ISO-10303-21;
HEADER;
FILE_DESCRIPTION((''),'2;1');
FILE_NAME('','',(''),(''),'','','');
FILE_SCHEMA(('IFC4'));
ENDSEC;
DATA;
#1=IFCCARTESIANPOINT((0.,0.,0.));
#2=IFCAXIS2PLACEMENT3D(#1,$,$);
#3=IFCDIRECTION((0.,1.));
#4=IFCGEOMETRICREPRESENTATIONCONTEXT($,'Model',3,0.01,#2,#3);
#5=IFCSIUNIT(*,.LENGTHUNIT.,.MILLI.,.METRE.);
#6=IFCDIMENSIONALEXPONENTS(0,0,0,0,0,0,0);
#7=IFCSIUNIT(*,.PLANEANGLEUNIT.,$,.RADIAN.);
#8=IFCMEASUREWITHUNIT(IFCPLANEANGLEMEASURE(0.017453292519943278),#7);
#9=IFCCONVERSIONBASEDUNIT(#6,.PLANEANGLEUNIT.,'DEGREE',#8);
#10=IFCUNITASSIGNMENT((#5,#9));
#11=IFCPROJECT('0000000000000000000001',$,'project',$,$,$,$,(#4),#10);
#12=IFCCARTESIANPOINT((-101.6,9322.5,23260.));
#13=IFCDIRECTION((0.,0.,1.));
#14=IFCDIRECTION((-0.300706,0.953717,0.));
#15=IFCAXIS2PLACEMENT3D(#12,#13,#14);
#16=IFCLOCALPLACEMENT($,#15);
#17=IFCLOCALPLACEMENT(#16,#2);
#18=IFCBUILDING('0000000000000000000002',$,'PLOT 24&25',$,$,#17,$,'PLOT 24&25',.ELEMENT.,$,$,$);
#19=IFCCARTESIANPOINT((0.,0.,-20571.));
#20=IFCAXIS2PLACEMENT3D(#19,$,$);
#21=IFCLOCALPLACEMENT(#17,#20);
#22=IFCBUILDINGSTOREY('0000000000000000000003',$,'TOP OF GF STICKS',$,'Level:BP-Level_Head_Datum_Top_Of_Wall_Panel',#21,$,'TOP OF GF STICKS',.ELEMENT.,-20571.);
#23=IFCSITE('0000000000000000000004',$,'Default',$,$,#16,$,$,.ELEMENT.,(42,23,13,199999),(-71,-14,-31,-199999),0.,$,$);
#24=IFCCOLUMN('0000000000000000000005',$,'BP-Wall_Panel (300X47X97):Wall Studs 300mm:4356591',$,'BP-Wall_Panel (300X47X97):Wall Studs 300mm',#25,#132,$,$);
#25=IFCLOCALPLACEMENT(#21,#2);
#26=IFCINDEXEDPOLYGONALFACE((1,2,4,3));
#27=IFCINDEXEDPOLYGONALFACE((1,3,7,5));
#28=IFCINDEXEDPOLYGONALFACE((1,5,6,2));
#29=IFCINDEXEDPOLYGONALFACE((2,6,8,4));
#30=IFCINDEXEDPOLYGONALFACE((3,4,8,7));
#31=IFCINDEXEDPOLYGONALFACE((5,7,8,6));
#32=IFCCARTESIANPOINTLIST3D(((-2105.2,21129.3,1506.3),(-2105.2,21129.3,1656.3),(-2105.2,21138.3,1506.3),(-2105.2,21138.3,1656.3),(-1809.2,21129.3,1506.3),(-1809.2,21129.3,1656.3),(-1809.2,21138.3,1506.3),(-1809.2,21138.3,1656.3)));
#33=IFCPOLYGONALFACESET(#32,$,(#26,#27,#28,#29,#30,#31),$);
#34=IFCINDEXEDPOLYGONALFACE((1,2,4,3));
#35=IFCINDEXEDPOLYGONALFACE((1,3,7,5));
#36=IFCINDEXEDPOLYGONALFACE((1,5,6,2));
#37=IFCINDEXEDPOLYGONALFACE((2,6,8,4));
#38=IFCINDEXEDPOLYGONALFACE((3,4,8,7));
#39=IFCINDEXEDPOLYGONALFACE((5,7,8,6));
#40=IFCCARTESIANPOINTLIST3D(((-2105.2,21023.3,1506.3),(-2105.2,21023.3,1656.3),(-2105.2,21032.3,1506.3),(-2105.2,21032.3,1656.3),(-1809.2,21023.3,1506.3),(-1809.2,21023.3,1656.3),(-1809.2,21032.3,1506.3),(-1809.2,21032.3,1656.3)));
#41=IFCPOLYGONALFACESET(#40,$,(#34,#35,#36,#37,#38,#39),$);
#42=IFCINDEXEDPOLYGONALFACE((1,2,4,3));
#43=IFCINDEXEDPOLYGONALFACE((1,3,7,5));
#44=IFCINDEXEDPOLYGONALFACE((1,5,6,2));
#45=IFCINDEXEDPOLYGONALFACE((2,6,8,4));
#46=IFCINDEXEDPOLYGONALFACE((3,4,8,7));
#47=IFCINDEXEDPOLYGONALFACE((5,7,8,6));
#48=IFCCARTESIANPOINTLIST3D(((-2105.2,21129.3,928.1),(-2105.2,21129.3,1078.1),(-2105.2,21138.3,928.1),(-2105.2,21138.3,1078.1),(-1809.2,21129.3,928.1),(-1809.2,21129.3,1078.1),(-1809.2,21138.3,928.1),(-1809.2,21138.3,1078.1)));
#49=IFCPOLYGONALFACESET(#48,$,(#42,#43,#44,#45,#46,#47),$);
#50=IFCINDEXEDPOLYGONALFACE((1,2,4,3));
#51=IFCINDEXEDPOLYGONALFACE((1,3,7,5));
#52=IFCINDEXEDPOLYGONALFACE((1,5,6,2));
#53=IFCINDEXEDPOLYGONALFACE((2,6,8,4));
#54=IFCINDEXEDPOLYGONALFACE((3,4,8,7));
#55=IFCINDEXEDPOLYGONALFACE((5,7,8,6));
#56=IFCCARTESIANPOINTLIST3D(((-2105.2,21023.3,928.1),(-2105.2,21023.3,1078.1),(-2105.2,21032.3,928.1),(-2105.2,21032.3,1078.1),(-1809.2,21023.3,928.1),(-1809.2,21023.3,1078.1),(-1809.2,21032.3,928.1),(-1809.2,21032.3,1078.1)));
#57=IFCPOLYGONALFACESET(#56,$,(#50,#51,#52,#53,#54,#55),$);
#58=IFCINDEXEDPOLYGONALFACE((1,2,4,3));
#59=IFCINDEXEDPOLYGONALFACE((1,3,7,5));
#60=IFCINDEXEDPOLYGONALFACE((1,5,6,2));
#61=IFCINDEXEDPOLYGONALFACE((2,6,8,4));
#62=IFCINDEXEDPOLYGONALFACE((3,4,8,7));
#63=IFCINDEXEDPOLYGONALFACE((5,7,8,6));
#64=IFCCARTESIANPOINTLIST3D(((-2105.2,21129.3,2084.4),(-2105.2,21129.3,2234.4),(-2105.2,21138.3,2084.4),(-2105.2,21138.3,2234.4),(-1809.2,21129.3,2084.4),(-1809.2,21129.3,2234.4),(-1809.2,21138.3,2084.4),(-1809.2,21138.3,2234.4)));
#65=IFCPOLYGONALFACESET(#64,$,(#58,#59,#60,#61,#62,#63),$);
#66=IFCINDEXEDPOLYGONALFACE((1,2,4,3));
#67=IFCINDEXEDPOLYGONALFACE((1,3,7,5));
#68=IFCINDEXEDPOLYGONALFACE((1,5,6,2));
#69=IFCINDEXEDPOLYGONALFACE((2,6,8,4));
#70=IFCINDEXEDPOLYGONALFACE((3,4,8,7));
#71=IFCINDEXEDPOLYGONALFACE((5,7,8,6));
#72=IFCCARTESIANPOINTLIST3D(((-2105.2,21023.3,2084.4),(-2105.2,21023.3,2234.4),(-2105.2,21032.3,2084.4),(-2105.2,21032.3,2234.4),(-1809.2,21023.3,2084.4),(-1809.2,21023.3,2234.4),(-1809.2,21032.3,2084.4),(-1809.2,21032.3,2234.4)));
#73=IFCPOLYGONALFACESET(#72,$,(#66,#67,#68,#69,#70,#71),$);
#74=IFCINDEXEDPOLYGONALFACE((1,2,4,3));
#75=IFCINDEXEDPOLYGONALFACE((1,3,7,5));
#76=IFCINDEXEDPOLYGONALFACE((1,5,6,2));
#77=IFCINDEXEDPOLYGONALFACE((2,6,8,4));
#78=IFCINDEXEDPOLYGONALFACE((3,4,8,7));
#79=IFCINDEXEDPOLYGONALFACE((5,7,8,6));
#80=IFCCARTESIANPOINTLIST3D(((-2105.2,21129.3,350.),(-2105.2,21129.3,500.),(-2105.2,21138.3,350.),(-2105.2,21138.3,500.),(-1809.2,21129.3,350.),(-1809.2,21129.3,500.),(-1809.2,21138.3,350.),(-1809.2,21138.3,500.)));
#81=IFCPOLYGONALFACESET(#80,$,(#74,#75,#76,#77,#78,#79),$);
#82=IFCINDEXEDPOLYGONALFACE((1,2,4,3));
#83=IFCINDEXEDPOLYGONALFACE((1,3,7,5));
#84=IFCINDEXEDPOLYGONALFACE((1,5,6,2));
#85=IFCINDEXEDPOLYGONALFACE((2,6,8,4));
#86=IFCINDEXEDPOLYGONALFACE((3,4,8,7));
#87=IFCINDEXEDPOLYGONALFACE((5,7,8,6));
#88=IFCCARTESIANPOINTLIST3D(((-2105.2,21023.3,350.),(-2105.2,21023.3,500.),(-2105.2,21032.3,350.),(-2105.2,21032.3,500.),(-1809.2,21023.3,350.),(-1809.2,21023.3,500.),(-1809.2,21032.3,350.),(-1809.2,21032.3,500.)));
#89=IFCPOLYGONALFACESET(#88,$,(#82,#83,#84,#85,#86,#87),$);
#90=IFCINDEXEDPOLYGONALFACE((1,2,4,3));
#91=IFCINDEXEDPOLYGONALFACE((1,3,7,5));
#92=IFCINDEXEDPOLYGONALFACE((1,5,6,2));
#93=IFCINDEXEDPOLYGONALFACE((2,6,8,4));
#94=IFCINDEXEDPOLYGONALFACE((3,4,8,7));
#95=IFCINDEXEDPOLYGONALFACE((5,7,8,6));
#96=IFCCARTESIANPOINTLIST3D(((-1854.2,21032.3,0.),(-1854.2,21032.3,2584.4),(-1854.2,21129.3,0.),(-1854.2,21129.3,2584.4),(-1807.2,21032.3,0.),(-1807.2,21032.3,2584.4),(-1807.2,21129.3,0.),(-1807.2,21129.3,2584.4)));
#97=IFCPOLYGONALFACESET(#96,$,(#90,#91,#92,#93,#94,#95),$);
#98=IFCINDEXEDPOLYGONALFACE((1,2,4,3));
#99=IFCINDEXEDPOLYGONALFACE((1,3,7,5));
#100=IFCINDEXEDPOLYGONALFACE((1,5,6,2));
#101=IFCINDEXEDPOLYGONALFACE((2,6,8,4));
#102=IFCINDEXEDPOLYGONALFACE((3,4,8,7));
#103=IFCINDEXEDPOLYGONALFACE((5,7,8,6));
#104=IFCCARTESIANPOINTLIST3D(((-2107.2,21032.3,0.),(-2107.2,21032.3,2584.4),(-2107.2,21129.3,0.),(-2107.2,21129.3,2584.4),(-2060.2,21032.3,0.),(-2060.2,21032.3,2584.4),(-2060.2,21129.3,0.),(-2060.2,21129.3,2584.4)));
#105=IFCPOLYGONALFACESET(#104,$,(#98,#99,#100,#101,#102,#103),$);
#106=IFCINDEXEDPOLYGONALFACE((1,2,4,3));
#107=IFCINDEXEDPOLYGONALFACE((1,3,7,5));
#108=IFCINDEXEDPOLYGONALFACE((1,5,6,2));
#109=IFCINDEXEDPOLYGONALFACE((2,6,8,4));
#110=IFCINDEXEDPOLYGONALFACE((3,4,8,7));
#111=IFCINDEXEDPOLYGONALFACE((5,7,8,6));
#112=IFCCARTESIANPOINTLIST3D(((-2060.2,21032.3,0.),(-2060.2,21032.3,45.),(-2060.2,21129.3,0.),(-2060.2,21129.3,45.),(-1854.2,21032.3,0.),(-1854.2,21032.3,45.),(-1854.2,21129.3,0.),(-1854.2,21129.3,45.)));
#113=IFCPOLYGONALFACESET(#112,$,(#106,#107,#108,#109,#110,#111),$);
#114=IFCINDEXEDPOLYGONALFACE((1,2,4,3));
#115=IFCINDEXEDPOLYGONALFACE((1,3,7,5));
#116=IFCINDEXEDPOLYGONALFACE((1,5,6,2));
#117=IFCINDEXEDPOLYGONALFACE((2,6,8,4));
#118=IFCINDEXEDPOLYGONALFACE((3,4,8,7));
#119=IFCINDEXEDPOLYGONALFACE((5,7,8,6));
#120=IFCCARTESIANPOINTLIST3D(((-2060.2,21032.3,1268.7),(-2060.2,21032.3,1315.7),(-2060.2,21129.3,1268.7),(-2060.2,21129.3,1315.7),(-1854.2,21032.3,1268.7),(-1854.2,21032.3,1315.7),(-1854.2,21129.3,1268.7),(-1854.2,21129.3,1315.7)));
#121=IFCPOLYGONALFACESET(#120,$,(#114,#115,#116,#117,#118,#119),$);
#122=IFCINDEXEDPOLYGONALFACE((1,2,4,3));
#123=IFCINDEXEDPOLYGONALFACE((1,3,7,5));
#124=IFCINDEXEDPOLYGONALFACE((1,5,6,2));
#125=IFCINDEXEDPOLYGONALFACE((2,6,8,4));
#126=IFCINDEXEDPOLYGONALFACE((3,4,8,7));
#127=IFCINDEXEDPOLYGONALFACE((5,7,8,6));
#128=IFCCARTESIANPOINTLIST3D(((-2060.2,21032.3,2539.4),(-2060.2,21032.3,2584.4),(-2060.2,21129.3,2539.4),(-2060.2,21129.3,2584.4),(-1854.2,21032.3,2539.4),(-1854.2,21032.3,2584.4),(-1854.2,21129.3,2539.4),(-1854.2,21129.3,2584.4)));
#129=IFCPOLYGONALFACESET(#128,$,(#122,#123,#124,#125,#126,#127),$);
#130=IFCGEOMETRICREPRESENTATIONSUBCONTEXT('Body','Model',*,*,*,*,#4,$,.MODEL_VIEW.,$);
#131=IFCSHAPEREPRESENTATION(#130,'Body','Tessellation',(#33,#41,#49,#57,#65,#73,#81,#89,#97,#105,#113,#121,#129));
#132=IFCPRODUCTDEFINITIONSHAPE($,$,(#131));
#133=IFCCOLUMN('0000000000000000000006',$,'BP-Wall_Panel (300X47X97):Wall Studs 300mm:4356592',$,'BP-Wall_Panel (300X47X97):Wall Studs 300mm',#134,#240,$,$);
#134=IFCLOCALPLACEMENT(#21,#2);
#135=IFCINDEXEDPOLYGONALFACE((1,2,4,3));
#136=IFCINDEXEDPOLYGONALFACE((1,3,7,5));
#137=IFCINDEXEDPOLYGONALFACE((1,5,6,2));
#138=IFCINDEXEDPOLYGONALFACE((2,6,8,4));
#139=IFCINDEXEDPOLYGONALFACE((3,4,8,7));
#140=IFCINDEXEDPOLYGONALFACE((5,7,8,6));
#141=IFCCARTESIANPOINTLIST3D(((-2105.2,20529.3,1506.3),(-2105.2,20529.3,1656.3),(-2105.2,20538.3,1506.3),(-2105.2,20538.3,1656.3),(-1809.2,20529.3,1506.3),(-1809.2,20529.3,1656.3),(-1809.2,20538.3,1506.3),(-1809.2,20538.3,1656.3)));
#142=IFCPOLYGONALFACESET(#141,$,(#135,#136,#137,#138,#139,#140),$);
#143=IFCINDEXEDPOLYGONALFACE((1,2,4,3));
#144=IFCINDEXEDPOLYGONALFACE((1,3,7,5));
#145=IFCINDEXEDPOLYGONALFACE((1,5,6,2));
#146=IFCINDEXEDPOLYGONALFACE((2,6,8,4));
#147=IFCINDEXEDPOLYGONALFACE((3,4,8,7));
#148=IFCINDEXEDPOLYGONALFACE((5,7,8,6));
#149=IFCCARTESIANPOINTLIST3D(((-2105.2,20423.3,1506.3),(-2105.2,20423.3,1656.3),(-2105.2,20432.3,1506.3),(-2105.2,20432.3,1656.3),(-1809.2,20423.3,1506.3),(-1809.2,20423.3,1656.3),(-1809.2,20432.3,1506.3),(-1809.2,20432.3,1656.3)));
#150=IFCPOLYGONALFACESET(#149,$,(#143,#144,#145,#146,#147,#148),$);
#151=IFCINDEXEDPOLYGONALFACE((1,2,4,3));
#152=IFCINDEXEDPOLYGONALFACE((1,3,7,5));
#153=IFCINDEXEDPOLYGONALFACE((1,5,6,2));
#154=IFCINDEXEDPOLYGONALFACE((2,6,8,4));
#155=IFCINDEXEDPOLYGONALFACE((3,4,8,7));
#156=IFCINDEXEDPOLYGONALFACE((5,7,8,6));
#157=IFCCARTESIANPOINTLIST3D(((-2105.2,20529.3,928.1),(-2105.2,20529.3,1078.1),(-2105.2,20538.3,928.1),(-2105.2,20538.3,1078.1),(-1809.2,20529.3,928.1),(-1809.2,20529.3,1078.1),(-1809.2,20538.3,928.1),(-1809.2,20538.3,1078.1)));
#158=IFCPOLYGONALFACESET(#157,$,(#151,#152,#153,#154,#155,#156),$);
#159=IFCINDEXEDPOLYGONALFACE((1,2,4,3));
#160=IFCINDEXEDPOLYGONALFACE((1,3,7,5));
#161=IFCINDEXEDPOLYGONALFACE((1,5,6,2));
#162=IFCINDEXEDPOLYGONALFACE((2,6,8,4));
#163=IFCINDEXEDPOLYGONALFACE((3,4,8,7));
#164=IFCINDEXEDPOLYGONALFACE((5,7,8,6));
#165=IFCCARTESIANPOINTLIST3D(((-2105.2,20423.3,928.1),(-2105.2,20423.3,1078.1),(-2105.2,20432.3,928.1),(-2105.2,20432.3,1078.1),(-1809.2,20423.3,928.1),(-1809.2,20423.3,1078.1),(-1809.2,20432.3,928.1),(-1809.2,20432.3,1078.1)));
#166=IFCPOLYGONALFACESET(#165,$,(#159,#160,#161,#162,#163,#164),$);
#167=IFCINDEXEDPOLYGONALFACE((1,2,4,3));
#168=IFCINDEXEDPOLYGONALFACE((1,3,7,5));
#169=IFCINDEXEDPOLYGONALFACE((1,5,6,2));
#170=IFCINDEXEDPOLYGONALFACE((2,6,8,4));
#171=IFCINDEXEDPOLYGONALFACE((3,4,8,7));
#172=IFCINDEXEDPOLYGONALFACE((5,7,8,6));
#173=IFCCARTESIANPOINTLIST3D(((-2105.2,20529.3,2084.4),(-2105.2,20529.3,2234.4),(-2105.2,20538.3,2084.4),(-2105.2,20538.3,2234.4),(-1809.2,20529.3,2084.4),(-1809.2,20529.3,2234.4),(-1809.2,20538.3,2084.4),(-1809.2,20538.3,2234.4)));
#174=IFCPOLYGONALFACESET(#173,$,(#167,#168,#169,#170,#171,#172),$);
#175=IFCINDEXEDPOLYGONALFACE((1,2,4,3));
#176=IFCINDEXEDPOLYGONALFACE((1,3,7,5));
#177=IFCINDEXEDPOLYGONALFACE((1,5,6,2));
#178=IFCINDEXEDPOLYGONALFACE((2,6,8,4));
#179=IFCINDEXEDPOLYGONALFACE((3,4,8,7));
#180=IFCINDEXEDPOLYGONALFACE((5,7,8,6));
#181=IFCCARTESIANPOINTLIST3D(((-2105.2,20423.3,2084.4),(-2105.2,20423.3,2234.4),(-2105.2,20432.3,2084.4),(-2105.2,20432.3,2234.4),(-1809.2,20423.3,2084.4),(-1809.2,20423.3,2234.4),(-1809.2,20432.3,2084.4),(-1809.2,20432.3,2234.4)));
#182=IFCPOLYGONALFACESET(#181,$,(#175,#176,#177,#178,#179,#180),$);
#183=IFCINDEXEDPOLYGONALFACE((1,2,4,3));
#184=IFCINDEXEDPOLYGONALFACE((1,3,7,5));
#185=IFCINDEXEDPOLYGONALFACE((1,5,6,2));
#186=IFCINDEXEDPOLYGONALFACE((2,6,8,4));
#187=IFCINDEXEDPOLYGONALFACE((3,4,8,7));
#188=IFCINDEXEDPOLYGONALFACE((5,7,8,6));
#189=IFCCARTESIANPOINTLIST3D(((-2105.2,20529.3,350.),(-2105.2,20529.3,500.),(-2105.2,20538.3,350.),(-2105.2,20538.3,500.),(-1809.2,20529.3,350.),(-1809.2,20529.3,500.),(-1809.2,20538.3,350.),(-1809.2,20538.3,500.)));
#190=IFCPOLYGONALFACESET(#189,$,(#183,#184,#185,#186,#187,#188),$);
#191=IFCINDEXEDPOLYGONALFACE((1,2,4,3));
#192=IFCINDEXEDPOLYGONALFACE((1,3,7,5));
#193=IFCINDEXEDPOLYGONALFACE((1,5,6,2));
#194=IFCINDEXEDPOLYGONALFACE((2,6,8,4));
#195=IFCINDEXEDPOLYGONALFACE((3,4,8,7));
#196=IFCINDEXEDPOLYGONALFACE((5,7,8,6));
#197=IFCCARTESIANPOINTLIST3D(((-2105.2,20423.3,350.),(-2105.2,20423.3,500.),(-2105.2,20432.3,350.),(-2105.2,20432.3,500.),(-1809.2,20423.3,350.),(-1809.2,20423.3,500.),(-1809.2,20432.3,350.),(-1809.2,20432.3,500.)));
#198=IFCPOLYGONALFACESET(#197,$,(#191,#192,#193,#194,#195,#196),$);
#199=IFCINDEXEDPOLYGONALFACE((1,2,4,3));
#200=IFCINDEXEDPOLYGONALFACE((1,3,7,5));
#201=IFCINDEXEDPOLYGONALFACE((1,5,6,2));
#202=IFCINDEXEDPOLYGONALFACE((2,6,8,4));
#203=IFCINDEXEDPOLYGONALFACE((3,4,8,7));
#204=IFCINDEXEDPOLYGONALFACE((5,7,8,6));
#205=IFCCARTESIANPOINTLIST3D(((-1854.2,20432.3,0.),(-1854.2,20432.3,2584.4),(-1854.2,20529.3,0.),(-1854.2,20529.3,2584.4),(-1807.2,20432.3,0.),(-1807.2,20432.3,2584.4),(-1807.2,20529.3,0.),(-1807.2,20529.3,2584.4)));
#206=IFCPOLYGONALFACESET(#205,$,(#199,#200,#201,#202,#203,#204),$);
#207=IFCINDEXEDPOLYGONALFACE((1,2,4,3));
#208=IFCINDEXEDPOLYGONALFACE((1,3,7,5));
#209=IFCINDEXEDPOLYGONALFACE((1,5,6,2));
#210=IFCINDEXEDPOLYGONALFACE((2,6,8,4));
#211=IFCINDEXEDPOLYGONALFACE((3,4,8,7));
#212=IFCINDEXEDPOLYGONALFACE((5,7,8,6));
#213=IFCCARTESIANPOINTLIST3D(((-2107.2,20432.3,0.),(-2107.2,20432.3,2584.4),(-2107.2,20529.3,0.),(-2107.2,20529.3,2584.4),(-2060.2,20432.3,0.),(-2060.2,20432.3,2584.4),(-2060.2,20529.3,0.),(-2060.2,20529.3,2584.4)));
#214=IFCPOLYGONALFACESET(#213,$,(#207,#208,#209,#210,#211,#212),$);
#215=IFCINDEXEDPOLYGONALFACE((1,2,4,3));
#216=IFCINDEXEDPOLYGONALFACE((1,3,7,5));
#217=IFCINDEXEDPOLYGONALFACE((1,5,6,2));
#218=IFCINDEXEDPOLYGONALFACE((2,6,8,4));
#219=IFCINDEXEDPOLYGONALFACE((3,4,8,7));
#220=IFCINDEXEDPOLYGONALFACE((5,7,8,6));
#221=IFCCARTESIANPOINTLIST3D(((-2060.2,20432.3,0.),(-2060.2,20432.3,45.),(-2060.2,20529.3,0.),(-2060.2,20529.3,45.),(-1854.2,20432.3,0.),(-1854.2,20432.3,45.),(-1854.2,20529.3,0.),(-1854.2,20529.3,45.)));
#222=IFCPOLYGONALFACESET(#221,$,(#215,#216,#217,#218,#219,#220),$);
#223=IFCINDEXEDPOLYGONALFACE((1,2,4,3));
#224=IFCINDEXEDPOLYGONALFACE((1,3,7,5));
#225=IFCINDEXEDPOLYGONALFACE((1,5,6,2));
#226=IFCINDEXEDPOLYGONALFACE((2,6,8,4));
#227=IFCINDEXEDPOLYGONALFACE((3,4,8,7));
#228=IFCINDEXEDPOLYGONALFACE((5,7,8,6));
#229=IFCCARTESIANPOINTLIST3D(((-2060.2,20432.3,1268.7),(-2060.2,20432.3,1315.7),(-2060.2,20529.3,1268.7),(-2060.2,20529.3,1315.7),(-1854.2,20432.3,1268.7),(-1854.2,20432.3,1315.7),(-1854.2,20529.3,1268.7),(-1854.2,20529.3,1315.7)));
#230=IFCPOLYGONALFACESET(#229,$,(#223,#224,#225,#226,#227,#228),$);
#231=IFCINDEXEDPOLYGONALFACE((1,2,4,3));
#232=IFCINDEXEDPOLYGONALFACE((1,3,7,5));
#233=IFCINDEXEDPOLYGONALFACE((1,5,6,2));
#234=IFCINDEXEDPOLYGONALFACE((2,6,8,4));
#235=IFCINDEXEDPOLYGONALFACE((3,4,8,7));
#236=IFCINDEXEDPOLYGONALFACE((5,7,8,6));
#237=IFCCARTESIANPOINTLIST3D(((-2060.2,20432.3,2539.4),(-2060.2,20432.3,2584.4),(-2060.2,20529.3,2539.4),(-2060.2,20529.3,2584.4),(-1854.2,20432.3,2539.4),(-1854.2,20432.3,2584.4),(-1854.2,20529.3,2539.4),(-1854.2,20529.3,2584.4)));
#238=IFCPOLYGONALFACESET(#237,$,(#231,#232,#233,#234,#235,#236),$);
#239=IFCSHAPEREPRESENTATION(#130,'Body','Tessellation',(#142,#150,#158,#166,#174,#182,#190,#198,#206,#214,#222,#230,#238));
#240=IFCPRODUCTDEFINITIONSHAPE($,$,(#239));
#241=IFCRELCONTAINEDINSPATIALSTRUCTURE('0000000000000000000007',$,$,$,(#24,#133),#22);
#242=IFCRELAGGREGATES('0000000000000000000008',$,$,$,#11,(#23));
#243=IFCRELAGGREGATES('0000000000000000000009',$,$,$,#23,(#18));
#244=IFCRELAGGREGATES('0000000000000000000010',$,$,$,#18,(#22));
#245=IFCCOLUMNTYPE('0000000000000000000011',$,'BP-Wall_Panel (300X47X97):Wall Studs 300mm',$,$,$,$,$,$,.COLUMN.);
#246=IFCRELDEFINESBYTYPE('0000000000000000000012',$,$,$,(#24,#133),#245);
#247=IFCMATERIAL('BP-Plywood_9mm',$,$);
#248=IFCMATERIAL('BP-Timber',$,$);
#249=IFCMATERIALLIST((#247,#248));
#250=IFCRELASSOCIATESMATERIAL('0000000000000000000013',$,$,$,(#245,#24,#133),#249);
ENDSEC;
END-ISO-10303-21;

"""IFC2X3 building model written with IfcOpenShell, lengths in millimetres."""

from ifc_helpers import new_model, entity, si_unit, converted_unit, direction, frame, frame_2d, origin, origin_2d_with_axis, place, context, subcontext, project, spatial, rectangle, extrude, source, transform, mapped, material, material_list, type_object, type_shapes, element, save


model = new_model("IFC2X3")

# Units and contexts
model_context = context("Model", 3, precision=0.01, world=origin(), true_north=direction((0.0, 1.0)))
body_context = subcontext(model_context, "Body", "Model", "MODEL_VIEW")
ifc_project = project(units=[si_unit("LENGTHUNIT", "METRE", prefix="MILLI"), converted_unit("PLANEANGLEUNIT", "DEGREE", entity("IfcPlaneAngleMeasure", 0.017453292519943278), si_unit("PLANEANGLEUNIT", "RADIAN"), dimensions=[0, 0, 0, 0, 0, 0, 0])], contexts=[model_context])

# Site, building, storey
site_placement = place(None, frame((-101.6, 9322.5, 23260.0), z_axis=(0.0, 0.0, 1.0), x_axis=(-0.300706, 0.953717, 0.0)))
site = spatial("IfcSite", under=ifc_project, at=site_placement, Name="Default", CompositionType="ELEMENT", RefLatitude=(42, 23, 13, 199999), RefLongitude=(-71, -14, -31, -199999), RefElevation=0.0)
building_placement = place(site_placement, origin())
building = spatial("IfcBuilding", under=site, at=building_placement, Name="PLOT 24&25", LongName="PLOT 24&25", CompositionType="ELEMENT")
storey_placement = place(building_placement, frame((0.0, 0.0, -20571.0)))
storey = spatial("IfcBuildingStorey", under=building, at=storey_placement, Name="TOP OF GF STICKS", ObjectType="Level:BP-Level_Head_Datum_Top_Of_Wall_Panel", LongName="TOP OF GF STICKS", CompositionType="ELEMENT", Elevation=-20571.0)

# Columns
ifc_material_1 = material(Name="BP-Plywood_9mm")
ifc_material_2 = material(Name="BP-Timber")
ifc_material_list = material_list([ifc_material_1, ifc_material_2])
column_type_1 = type_object("IfcColumnType", Name="BP-Wall_Panel (300X47X97):Wall Studs 300mm", PredefinedType="COLUMN", material=ifc_material_list)
shared_shape_1 = source(origin(), body_context, "Body", "SweptSolid", [
    extrude(rectangle(XDim=296.0, YDim=9.0, at=origin_2d_with_axis()), frame((53.0, 0.0, -19064.7), z_axis=(0.0, 0.0, 1.0), x_axis=(0.0, -1.0, 0.0)), (0.0, 0.0, 1.0), 150.0),
    extrude(rectangle(XDim=9.0, YDim=296.0, at=origin_2d_with_axis()), frame((-53.0, 0.0, -19064.7), z_axis=(0.0, 0.0, 1.0), x_axis=(-1.0, 0.0, 0.0)), (0.0, 0.0, 1.0), 150.0),
    extrude(rectangle(XDim=296.0, YDim=9.0, at=origin_2d_with_axis()), frame((53.0, 0.0, -19642.9), z_axis=(0.0, 0.0, 1.0), x_axis=(0.0, -1.0, 0.0)), (0.0, 0.0, 1.0), 150.0),
    extrude(rectangle(XDim=9.0, YDim=296.0, at=origin_2d_with_axis()), frame((-53.0, 0.0, -19642.9), z_axis=(0.0, 0.0, 1.0), x_axis=(-1.0, 0.0, 0.0)), (0.0, 0.0, 1.0), 150.0),
    extrude(rectangle(XDim=296.0, YDim=9.0, at=origin_2d_with_axis()), frame((53.0, 0.0, -18486.6), z_axis=(0.0, 0.0, 1.0), x_axis=(0.0, -1.0, 0.0)), (0.0, 0.0, 1.0), 150.0),
    extrude(rectangle(XDim=9.0, YDim=296.0, at=origin_2d_with_axis()), frame((-53.0, 0.0, -18486.6), z_axis=(0.0, 0.0, 1.0), x_axis=(-1.0, 0.0, 0.0)), (0.0, 0.0, 1.0), 150.0),
    extrude(rectangle(XDim=296.0, YDim=9.0, at=origin_2d_with_axis()), frame((53.0, 0.0, -20221.0), z_axis=(0.0, 0.0, 1.0), x_axis=(0.0, -1.0, 0.0)), (0.0, 0.0, 1.0), 150.0),
    extrude(rectangle(XDim=9.0, YDim=296.0, at=origin_2d_with_axis()), frame((-53.0, 0.0, -20221.0), z_axis=(0.0, 0.0, 1.0), x_axis=(-1.0, 0.0, 0.0)), (0.0, 0.0, 1.0), 150.0),
    extrude(rectangle(XDim=97.0, YDim=47.0, at=origin_2d_with_axis()), frame((0.0, -126.5, -20571.0), z_axis=(0.0, 0.0, 1.0), x_axis=(-1.0, 0.0, 0.0)), (0.0, 0.0, 1.0), 2584.4),
    extrude(rectangle(XDim=97.0, YDim=47.0, at=frame_2d((0.0, 0.0), x_axis=(1.0, 0.0))), frame((0.0, 126.5, -20571.0), z_axis=(0.0, 0.0, 1.0), x_axis=(-1.0, 0.0, 0.0)), (0.0, 0.0, 1.0), 2584.4),
    extrude(rectangle(XDim=206.0, YDim=97.0, at=origin_2d_with_axis()), frame((0.0, 0.0, -20571.0), z_axis=(0.0, 0.0, 1.0), x_axis=(0.0, -1.0, 0.0)), (0.0, 0.0, 1.0), 45.0),
    extrude(rectangle(XDim=206.0, YDim=97.0, at=origin_2d_with_axis()), frame((0.0, 0.0, -19302.3), z_axis=(0.0, 0.0, 1.0), x_axis=(0.0, -1.0, 0.0)), (0.0, 0.0, 1.0), 47.0),
    extrude(rectangle(XDim=206.0, YDim=97.0, at=origin_2d_with_axis()), frame((0.0, 0.0, -18031.6), z_axis=(0.0, 0.0, 1.0), x_axis=(0.0, -1.0, 0.0)), (0.0, 0.0, 1.0), 45.0),
])
type_shapes(column_type_1, [shared_shape_1])
for number, where, z_axis, x_axis, name in (
    (1, (-1957.2, 21080.8, 20571.0), (0.0, 0.0, 1.0), (0.0, 1.0, 0.0), "BP-Wall_Panel (300X47X97):Wall Studs 300mm:4356591"),
    (2, (-1957.2, 20480.8, 20571.0), (0.0, 0.0, 1.0), (0.0, 1.0, 0.0), "BP-Wall_Panel (300X47X97):Wall Studs 300mm:4356592"),
):
    element("IfcColumn", number, at=place(storey_placement, frame(where, z_axis=z_axis, x_axis=x_axis)), inside=storey, type_object=column_type_1, material=ifc_material_list, Name=name, ObjectType="BP-Wall_Panel (300X47X97):Wall Studs 300mm", context=body_context, shape_type="MappedRepresentation", body=[
        mapped(shared_shape_1, transform((0.0, 0.0, 0.0), scale=1.0)),
    ])

save(model, "model.ifc")
